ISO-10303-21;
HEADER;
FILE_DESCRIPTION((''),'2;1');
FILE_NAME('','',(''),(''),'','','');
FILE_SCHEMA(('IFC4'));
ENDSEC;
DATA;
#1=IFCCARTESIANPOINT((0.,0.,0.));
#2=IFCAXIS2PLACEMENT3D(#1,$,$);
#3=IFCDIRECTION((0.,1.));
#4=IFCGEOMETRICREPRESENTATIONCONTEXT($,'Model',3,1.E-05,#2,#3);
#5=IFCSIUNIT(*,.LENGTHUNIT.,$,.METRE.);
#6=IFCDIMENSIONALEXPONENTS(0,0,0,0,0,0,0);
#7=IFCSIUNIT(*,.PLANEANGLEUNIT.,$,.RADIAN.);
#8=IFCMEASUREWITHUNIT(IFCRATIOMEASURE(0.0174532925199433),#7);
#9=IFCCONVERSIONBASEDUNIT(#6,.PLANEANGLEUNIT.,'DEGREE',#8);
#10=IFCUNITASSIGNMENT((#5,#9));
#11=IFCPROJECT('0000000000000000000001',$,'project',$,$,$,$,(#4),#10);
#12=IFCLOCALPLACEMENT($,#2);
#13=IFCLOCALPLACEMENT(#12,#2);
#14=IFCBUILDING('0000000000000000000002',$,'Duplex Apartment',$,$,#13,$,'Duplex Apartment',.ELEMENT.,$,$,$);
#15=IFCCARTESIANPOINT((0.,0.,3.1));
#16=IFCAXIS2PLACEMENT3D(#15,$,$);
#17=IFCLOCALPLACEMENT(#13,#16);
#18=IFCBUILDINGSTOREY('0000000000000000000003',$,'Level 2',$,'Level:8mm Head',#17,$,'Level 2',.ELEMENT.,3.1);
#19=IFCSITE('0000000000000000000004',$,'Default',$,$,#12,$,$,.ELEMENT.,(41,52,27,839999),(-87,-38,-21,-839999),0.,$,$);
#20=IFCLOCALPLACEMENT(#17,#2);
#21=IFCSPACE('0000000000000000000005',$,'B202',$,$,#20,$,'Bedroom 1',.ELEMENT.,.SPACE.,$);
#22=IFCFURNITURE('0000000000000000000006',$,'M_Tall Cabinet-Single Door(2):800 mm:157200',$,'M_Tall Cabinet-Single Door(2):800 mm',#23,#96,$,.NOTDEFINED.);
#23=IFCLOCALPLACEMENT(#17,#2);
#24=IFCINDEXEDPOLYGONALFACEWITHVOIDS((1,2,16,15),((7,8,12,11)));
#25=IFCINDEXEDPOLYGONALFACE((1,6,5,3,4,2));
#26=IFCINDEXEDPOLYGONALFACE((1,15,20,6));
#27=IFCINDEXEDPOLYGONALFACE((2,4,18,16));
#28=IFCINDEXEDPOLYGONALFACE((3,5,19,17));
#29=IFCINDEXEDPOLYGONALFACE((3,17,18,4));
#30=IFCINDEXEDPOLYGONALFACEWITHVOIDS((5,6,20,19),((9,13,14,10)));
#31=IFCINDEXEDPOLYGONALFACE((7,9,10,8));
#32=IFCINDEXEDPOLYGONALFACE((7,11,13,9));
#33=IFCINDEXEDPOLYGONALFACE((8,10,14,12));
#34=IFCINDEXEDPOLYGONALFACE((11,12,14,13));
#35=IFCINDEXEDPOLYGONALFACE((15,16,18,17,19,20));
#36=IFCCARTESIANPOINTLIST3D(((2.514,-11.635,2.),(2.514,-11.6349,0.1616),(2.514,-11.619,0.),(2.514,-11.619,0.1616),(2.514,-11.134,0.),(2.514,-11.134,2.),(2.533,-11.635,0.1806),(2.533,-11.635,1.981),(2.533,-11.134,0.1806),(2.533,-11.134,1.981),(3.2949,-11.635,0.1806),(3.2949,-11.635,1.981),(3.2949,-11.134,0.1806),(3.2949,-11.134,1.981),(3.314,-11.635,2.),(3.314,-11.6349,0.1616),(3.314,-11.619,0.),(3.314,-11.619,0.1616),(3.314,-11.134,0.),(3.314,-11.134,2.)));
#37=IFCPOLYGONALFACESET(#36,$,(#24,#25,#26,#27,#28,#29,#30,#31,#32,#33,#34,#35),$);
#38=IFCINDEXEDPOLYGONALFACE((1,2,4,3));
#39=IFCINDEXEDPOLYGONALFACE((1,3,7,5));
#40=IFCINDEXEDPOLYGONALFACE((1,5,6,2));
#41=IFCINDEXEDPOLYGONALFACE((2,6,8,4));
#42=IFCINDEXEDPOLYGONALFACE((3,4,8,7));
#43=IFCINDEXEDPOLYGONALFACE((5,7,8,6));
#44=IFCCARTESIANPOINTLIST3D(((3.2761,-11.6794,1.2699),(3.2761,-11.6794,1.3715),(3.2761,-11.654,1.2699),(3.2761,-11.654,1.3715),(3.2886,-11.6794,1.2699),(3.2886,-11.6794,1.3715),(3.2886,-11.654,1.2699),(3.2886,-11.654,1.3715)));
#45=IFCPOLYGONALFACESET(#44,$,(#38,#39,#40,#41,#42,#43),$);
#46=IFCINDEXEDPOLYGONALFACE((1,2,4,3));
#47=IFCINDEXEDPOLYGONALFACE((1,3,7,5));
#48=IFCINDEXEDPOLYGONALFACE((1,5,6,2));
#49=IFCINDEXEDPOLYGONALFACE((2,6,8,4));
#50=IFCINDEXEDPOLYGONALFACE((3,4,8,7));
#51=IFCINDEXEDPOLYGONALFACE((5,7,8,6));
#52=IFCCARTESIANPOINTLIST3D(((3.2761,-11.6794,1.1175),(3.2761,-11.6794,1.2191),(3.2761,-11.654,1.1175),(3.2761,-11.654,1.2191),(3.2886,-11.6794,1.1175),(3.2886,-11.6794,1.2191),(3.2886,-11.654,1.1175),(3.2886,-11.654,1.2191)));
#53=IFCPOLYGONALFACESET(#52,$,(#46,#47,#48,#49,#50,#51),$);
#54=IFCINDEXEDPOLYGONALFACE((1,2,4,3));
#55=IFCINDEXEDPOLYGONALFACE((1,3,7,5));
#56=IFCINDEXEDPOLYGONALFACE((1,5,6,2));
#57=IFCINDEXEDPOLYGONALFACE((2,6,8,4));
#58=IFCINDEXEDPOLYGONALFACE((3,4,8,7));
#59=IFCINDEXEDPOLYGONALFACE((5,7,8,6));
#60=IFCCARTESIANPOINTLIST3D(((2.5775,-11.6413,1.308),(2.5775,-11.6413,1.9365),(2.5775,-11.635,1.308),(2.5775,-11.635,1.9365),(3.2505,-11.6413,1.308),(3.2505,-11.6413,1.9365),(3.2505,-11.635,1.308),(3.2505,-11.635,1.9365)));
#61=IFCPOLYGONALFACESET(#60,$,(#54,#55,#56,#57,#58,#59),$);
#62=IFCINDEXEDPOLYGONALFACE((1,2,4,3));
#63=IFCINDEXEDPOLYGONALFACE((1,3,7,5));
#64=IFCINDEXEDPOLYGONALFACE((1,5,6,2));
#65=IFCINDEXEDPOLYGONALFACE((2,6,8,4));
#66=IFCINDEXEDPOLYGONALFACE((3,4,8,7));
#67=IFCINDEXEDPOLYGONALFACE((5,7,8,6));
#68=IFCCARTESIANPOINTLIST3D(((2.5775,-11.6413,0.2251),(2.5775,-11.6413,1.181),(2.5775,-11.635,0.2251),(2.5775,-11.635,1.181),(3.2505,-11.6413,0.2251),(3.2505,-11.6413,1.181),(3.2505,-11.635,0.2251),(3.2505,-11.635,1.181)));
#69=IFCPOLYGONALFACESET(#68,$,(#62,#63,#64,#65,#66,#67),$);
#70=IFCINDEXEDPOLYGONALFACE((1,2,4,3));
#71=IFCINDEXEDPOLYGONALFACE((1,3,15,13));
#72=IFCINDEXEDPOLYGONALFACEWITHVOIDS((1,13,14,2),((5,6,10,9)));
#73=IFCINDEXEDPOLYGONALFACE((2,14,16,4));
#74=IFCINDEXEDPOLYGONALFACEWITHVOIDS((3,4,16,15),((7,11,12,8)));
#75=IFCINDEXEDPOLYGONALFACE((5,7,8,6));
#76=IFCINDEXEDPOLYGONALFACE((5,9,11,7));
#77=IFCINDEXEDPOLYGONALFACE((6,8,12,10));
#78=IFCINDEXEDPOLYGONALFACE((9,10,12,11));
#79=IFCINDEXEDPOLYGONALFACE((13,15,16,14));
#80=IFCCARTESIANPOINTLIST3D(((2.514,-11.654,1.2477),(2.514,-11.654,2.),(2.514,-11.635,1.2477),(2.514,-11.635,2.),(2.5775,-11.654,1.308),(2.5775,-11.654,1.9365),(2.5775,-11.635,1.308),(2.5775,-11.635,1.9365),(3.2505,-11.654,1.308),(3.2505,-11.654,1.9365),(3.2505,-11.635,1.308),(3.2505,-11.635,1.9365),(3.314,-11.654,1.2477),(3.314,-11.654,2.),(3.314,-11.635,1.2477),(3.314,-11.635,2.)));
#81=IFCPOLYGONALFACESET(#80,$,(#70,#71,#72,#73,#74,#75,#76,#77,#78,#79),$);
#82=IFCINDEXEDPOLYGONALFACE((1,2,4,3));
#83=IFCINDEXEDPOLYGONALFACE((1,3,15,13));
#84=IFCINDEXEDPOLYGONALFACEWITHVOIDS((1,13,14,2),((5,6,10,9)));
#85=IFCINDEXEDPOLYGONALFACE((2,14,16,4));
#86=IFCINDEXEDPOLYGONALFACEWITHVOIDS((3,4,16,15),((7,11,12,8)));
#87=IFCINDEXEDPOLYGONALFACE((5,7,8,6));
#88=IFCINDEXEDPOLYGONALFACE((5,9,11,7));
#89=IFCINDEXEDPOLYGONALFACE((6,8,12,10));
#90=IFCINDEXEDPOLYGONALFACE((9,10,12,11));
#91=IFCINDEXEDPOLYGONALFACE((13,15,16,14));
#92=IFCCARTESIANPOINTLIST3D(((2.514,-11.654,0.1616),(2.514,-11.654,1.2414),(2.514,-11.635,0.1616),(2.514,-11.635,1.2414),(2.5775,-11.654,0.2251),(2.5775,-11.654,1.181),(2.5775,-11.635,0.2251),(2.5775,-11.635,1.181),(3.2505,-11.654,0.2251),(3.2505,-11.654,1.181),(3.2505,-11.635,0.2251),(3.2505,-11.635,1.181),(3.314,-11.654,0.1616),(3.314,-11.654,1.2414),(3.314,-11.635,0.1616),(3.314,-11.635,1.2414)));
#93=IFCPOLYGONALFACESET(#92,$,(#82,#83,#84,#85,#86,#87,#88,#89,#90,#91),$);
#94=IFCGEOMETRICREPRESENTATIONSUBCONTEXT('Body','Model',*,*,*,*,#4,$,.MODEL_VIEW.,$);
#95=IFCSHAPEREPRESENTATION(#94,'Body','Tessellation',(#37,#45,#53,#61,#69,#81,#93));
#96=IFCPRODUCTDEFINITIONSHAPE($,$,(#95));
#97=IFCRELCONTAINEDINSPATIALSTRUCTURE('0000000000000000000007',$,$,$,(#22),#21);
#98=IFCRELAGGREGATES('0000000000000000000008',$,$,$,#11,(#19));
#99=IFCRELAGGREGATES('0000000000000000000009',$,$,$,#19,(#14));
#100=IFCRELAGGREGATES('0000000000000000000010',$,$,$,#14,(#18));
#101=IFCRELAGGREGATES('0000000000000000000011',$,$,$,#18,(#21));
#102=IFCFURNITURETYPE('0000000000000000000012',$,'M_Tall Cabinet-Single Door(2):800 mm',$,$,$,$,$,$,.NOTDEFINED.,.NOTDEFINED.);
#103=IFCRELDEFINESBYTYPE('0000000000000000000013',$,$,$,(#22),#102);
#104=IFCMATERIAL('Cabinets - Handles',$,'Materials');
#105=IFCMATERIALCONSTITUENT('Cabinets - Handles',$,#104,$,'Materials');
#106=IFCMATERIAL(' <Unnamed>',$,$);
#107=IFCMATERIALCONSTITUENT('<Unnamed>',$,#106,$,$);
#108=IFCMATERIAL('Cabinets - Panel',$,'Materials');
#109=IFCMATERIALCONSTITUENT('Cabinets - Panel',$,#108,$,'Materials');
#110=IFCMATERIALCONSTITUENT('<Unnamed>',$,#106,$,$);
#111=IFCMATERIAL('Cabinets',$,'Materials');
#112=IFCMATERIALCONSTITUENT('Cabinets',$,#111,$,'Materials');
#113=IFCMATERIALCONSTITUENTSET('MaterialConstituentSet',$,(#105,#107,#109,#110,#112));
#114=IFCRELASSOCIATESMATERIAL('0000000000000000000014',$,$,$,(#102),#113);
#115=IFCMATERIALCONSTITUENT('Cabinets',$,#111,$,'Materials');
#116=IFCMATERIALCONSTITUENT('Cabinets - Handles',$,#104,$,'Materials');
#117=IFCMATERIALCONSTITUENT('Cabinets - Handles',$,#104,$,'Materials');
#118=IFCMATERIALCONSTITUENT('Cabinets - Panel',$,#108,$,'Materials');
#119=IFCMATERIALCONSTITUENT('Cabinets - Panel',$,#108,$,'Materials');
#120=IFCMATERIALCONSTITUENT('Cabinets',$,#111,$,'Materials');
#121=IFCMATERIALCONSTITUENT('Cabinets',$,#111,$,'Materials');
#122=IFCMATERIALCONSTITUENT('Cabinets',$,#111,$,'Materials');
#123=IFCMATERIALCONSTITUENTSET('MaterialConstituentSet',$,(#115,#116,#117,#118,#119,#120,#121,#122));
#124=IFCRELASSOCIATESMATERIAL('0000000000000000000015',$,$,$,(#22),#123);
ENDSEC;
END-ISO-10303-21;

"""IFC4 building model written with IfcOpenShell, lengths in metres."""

from ifc_helpers import new_model, entity, si_unit, converted_unit, direction, frame, origin, place, context, subcontext, project, spatial, indexed_curve, outline, extrude, source, transform, mapped, material, constituent, constituent_set, type_object, type_shapes, element, save


model = new_model("IFC4")

# Units and contexts
model_context = context("Model", 3, precision=1e-05, world=origin(), true_north=direction((0.0, 1.0)))
body_context = subcontext(model_context, "Body", "Model", "MODEL_VIEW")
ifc_project = project(units=[si_unit("LENGTHUNIT", "METRE"), converted_unit("PLANEANGLEUNIT", "DEGREE", entity("IfcRatioMeasure", 0.0174532925199433), si_unit("PLANEANGLEUNIT", "RADIAN"), dimensions=[0, 0, 0, 0, 0, 0, 0])], contexts=[model_context])

# Site, building, storey
site_placement = place(None, origin())
site = spatial("IfcSite", under=ifc_project, at=site_placement, Name="Default", CompositionType="ELEMENT", RefLatitude=(41, 52, 27, 839999), RefLongitude=(-87, -38, -21, -839999), RefElevation=0.0)
building_placement = place(site_placement, origin())
building = spatial("IfcBuilding", under=site, at=building_placement, Name="Duplex Apartment", LongName="Duplex Apartment", CompositionType="ELEMENT")
storey_placement = place(building_placement, frame((0.0, 0.0, 3.1)))
storey = spatial("IfcBuildingStorey", under=building, at=storey_placement, Name="Level 2", ObjectType="Level:8mm Head", LongName="Level 2", CompositionType="ELEMENT", Elevation=3.1)

# Shared definitions
space_1_placement = place(storey_placement, origin())
space_1 = spatial("IfcSpace", under=storey, at=space_1_placement, Name="B202", LongName="Bedroom 1", CompositionType="ELEMENT", PredefinedType="SPACE")

# Furniture, opening
ifc_material_1 = material(Name="Cabinets", Category="Materials")
ifc_constituent_1 = constituent(ifc_material_1, Name="Cabinets", Category="Materials")
ifc_material_2 = material(Name="Cabinets - Handles", Category="Materials")
ifc_constituent_2 = constituent(ifc_material_2, Name="Cabinets - Handles", Category="Materials")
ifc_constituent_3 = constituent(ifc_material_2, Name="Cabinets - Handles", Category="Materials")
ifc_material_3 = material(Name="Cabinets - Panel", Category="Materials")
ifc_constituent_4 = constituent(ifc_material_3, Name="Cabinets - Panel", Category="Materials")
ifc_constituent_5 = constituent(ifc_material_3, Name="Cabinets - Panel", Category="Materials")
ifc_constituent_6 = constituent(ifc_material_1, Name="Cabinets", Category="Materials")
ifc_constituent_7 = constituent(ifc_material_1, Name="Cabinets", Category="Materials")
ifc_constituent_8 = constituent(ifc_material_1, Name="Cabinets", Category="Materials")
ifc_constituent_set_1 = constituent_set(constituents=[ifc_constituent_1, ifc_constituent_2, ifc_constituent_3, ifc_constituent_4, ifc_constituent_5, ifc_constituent_6, ifc_constituent_7, ifc_constituent_8], Name="MaterialConstituentSet")
ifc_constituent_9 = constituent(ifc_material_2, Name="Cabinets - Handles", Category="Materials")
ifc_material_4 = material(Name=" <Unnamed>")
ifc_constituent_10 = constituent(ifc_material_4, Name="<Unnamed>")
ifc_constituent_11 = constituent(ifc_material_3, Name="Cabinets - Panel", Category="Materials")
ifc_constituent_12 = constituent(ifc_material_4, Name="<Unnamed>")
ifc_constituent_13 = constituent(ifc_material_1, Name="Cabinets", Category="Materials")
ifc_constituent_set_2 = constituent_set(constituents=[ifc_constituent_9, ifc_constituent_10, ifc_constituent_11, ifc_constituent_12, ifc_constituent_13], Name="MaterialConstituentSet")
furniture_type_1 = type_object("IfcFurnitureType", Name="M_Tall Cabinet-Single Door(2):800 mm", AssemblyPlace="NOTDEFINED", PredefinedType="NOTDEFINED", material=ifc_constituent_set_2)
shared_shape_1 = source(origin(), body_context, "Body", "SweptSolid", [
    extrude(outline(indexed_curve([(-0.1723, 0.5589), (-0.1723, -1.2795), (0.3286, -1.2795), (0.3287, 0.7205), (-0.1563, 0.7205), (-0.1563, 0.5589), (-0.1723, 0.5589)], self_intersect=False)), frame((-0.3813, -0.3286, 0.7205), z_axis=(-1.0, 0.0, 0.0), x_axis=(0.0, 1.0, 0.0)), (0.0, 0.0, -1.0), 0.8),
    extrude(outline(indexed_curve([(-0.0127, -0.0063), (0.0127, -0.0063), (0.0127, 0.0063), (-0.0127, 0.0063), (-0.0127, -0.0063)], self_intersect=False)), frame((0.3871, -0.5327, 1.2699), z_axis=(0.0, 0.0, 1.0), x_axis=(0.0, 1.0, 0.0)), (0.0, 0.0, 1.0), 0.1016),
    extrude(outline(indexed_curve([(-0.0127, -0.0063), (0.0127, -0.0063), (0.0127, 0.0063), (-0.0127, 0.0063), (-0.0127, -0.0063)], self_intersect=False)), frame((0.3871, -0.5327, 1.1175), z_axis=(0.0, 0.0, 1.0), x_axis=(0.0, 1.0, 0.0)), (0.0, 0.0, 1.0), 0.1016),
    extrude(outline(indexed_curve([(-0.0032, -0.3365), (0.0032, -0.3365), (0.0032, 0.3365), (-0.0032, 0.3365), (-0.0032, -0.3365)], self_intersect=False)), frame((0.0187, -0.5041, 1.308), z_axis=(0.0, 0.0, 1.0), x_axis=(0.0, 1.0, 0.0)), (0.0, 0.0, 1.0), 0.6285),
    extrude(outline(indexed_curve([(-0.0032, -0.3365), (0.0032, -0.3365), (0.0032, 0.3365), (-0.0032, 0.3365), (-0.0032, -0.3365)], self_intersect=False)), frame((0.0187, -0.5041, 0.2251), z_axis=(0.0, 0.0, 1.0), x_axis=(0.0, 1.0, 0.0)), (0.0, 0.0, 1.0), 0.956),
    extrude(outline(indexed_curve([(-0.3761, -0.4), (0.3761, -0.4), (0.3761, 0.4), (-0.3761, 0.4), (-0.3761, -0.4)], self_intersect=False), holes=[indexed_curve([(-0.3126, -0.3365), (-0.3126, 0.3365), (0.3158, 0.3365), (0.3158, -0.3365), (-0.3126, -0.3365)], self_intersect=False)]), frame((0.0187, -0.52, 1.6239), z_axis=(0.0, 1.0, 0.0), x_axis=(0.0, 0.0, -1.0)), (0.0, 0.0, 1.0), 0.0191),
    extrude(outline(indexed_curve([(-0.4, -0.5399), (0.4, -0.5399), (0.4, 0.5399), (-0.4, 0.5399), (-0.4, -0.5399)], self_intersect=False), holes=[indexed_curve([(-0.3365, 0.4796), (0.3365, 0.4796), (0.3365, -0.4764), (-0.3365, -0.4764), (-0.3365, 0.4796)], self_intersect=False)]), frame((0.0187, -0.52, 0.7015), z_axis=(0.0, 1.0, 0.0), x_axis=(-1.0, 0.0, 0.0)), (0.0, 0.0, 1.0), 0.0191),
    extrude(outline(indexed_curve([(-0.0095, -0.381), (0.0095, -0.381), (0.0095, 0.381), (-0.0095, 0.381), (-0.0095, -0.381)], self_intersect=False)), frame((0.0187, -0.0095, 0.1806), z_axis=(0.0, 0.0, 1.0), x_axis=(0.0, 1.0, 0.0)), (0.0, 0.0, 1.0), 1.8003),
])
type_shapes(furniture_type_1, [shared_shape_1])
furniture_1_placement = place(space_1_placement, frame((2.8953, -11.134, 0.0)))
furniture_1 = element("IfcFurniture", 1, at=furniture_1_placement, inside=space_1, type_object=furniture_type_1, material=ifc_constituent_set_1, Name="M_Tall Cabinet-Single Door(2):800 mm:157200", ObjectType="M_Tall Cabinet-Single Door(2):800 mm", PredefinedType="NOTDEFINED", context=body_context, shape_type="MappedRepresentation", body=[
    mapped(shared_shape_1, transform((0.0, 0.0, 0.0), scale=1.0)),
])
opening_1_placement = place(storey_placement, frame((2.8953, -11.134, 3.1)))
element("IfcOpeningElement", 2, at=opening_1_placement, cuts=furniture_1, ObjectType="Opening", PredefinedType="OPENING", context=body_context, shape_type="SweptSolid", body=[
    extrude(outline(indexed_curve([(-0.381, -0.9002), (0.381, -0.9002), (0.381, 0.9002), (-0.381, 0.9002), (-0.381, -0.9002)], self_intersect=False)), frame((0.0187, 0.0, -2.0192), z_axis=(0.0, -1.0, 0.0), x_axis=(-1.0, 0.0, 0.0)), (0.0, 0.0, 1.0), 0.501),
])

save(model, "model.ifc")
